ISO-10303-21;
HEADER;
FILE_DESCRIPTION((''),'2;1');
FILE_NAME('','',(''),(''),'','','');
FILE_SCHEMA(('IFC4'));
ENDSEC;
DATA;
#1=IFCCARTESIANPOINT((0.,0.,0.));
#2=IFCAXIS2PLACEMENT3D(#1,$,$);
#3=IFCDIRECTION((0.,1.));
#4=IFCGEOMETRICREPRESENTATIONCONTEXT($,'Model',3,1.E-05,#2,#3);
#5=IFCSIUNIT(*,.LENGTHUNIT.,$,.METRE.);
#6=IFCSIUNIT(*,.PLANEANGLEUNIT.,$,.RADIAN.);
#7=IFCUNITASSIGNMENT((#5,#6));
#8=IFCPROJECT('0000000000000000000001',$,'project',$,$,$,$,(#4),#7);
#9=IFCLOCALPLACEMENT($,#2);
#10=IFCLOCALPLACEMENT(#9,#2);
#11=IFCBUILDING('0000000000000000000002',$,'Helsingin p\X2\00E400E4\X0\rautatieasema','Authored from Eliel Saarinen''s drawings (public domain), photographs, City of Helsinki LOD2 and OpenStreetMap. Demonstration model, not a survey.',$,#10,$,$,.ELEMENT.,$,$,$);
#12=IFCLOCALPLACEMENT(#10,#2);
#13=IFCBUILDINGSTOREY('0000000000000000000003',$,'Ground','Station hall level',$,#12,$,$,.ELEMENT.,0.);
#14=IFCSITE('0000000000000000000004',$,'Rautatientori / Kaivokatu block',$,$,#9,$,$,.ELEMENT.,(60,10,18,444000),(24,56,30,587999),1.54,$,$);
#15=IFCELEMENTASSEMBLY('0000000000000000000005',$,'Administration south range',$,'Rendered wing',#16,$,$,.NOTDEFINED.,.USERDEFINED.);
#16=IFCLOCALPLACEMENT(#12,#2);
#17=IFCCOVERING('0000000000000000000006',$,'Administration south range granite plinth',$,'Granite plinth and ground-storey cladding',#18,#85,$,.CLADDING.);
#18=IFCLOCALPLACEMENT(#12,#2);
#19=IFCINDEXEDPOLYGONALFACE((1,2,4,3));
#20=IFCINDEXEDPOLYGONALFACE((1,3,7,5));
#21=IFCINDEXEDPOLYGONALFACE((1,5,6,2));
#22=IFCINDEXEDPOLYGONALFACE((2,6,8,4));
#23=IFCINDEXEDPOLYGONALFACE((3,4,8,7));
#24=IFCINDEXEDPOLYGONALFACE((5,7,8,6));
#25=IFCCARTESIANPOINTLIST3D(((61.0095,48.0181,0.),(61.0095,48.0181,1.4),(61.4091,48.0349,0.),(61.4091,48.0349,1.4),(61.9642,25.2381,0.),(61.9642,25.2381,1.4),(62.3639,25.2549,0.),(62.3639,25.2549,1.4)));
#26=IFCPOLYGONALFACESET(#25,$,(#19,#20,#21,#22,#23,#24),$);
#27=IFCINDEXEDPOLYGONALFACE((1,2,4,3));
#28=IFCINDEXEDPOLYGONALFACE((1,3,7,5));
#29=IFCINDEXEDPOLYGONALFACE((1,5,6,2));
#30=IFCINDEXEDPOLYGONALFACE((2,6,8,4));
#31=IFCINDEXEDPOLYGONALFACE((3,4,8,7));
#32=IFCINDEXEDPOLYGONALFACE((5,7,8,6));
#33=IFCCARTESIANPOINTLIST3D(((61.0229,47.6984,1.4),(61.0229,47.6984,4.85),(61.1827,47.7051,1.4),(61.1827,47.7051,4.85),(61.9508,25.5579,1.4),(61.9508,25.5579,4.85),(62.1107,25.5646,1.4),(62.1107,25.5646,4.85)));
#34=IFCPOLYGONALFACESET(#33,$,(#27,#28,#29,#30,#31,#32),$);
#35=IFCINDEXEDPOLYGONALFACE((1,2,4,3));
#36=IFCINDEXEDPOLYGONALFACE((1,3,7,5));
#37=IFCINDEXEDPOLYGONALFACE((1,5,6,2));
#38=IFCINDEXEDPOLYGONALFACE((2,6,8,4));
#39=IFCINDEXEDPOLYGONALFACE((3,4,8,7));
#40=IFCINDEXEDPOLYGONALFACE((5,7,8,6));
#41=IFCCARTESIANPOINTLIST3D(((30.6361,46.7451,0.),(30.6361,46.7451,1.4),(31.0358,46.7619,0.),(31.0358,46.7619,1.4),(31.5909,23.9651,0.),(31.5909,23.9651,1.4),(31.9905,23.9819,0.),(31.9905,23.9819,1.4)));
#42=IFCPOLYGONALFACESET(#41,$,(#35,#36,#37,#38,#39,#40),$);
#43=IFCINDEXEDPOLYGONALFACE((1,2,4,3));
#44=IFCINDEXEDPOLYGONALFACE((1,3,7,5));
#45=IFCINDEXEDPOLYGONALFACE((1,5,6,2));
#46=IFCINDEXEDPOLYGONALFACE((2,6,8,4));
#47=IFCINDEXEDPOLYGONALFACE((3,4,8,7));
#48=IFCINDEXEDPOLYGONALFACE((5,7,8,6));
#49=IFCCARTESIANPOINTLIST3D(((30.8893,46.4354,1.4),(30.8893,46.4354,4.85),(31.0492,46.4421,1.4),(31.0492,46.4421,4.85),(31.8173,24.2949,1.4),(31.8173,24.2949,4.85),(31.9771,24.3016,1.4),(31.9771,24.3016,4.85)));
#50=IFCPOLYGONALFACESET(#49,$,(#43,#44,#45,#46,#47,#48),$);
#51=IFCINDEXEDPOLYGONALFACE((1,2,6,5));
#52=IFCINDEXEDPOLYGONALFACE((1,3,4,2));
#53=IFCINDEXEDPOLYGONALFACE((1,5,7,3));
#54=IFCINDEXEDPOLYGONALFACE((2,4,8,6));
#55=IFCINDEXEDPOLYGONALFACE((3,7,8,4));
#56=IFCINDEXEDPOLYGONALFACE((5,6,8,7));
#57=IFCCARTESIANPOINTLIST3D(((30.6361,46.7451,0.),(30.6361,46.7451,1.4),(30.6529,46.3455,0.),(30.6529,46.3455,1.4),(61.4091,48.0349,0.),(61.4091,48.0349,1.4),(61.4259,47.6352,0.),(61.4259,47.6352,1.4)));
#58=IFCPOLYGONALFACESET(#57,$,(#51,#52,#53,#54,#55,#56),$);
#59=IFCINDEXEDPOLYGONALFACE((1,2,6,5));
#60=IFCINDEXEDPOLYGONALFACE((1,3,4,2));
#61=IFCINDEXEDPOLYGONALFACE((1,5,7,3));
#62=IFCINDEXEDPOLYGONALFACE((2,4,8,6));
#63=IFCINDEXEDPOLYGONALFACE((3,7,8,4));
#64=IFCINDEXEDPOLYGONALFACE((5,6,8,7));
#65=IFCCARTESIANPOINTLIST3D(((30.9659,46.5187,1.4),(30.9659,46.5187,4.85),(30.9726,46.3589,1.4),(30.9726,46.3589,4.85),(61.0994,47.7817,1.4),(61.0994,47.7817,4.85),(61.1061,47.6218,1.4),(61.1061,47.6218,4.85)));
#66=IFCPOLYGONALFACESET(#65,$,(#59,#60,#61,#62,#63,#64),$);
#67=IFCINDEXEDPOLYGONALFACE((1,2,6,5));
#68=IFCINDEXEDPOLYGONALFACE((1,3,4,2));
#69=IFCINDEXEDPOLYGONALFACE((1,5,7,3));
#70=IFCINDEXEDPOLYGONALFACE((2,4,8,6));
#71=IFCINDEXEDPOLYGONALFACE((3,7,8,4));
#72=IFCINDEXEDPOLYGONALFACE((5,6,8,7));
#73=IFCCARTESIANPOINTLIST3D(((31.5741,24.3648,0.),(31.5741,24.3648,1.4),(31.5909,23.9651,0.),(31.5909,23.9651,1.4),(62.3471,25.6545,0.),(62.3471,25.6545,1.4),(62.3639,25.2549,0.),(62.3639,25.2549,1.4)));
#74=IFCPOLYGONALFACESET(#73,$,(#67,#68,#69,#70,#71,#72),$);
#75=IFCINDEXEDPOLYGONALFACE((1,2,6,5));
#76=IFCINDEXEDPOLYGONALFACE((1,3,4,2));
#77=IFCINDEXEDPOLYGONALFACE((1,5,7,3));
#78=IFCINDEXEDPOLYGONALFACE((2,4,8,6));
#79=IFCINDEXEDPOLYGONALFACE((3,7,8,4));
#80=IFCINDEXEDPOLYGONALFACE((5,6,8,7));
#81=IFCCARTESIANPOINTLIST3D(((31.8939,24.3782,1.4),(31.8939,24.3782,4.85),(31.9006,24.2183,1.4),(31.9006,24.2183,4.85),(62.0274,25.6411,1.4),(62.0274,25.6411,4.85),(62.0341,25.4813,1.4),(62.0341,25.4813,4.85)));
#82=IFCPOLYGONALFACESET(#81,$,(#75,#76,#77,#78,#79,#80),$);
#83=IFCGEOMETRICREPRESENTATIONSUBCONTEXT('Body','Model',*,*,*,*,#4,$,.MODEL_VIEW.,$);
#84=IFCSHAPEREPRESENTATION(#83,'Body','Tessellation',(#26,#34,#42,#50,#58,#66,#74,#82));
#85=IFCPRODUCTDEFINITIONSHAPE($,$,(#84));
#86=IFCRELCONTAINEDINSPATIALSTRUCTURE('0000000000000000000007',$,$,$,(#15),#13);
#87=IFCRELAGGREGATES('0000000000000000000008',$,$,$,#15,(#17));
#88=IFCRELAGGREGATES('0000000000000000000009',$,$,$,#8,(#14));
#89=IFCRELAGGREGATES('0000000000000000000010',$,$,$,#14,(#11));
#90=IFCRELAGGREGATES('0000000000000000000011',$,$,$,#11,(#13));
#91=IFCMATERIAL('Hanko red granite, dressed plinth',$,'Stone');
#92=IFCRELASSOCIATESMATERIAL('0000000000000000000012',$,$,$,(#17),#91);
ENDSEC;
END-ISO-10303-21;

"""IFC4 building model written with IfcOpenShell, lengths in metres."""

from ifc_helpers import new_model, si_unit, direction, frame, frame_2d, origin, place, context, subcontext, project, spatial, rectangle, extrude, material, element, aggregate, save


model = new_model("IFC4")

# Units and contexts
model_context = context("Model", 3, precision=1e-05, world=origin(), true_north=direction((0.0, 1.0)))
body_context = subcontext(model_context, "Body", "Model", "MODEL_VIEW")
ifc_project = project(units=[si_unit("LENGTHUNIT", "METRE"), si_unit("PLANEANGLEUNIT", "RADIAN")], contexts=[model_context])

# Site, building, storey
site_placement = place(None, origin())
site = spatial("IfcSite", under=ifc_project, at=site_placement, Name="Rautatientori / Kaivokatu block", CompositionType="ELEMENT", RefLatitude=(60, 10, 18, 444000), RefLongitude=(24, 56, 30, 587999), RefElevation=1.54)
building_placement = place(site_placement, origin())
building = spatial("IfcBuilding", under=site, at=building_placement, Name="Helsingin päärautatieasema", Description="Authored from Eliel Saarinen's drawings (public domain), photographs, City of Helsinki LOD2 and OpenStreetMap. Demonstration model, not a survey.", CompositionType="ELEMENT")
storey_placement = place(building_placement, origin())
storey = spatial("IfcBuildingStorey", under=building, at=storey_placement, Name="Ground", Description="Station hall level", CompositionType="ELEMENT", Elevation=0.0)

# Element assembly
assembly_1_placement = place(building_placement, origin())
assembly_1 = element("IfcElementAssembly", 1, at=assembly_1_placement, inside=storey, Name="Administration south range", ObjectType="Rendered wing", AssemblyPlace="NOTDEFINED", PredefinedType="USERDEFINED")
ifc_material_1 = material(Name="Hanko red granite, dressed plinth", Category="Stone")

# Covering
covering_placement = place(building_placement, origin())
covering = element("IfcCovering", 2, at=covering_placement, material=ifc_material_1, Name="Administration south range granite plinth", ObjectType="Granite plinth and ground-storey cladding", PredefinedType="CLADDING", context=body_context, shape_type="SweptSolid", body=[
    extrude(rectangle(XDim=22.8, YDim=0.4, at=frame_2d((0.0, 0.0), x_axis=(-0.041876, 0.999123))), frame((61.6867, 36.6365, 0.0)), (0.0, 0.0, 1.0), 1.4),
    extrude(rectangle(XDim=22.16, YDim=0.16, at=frame_2d((0.0, 0.0), x_axis=(-0.041876, 0.999123))), frame((61.5668, 36.6315, 1.4)), (0.0, 0.0, 1.0), 3.45),
    extrude(rectangle(XDim=22.8, YDim=0.4, at=frame_2d((0.0, 0.0), x_axis=(0.041876, -0.999123))), frame((31.3133, 35.3635, 0.0)), (0.0, 0.0, 1.0), 1.4),
    extrude(rectangle(XDim=22.16, YDim=0.16, at=frame_2d((0.0, 0.0), x_axis=(0.041876, -0.999123))), frame((31.4332, 35.3685, 1.4)), (0.0, 0.0, 1.0), 3.45),
    extrude(rectangle(XDim=30.8, YDim=0.4, at=frame_2d((0.0, 0.0), x_axis=(-0.999123, -0.041876))), frame((46.031, 47.1902, 0.0)), (0.0, 0.0, 1.0), 1.4),
    extrude(rectangle(XDim=30.16, YDim=0.16, at=frame_2d((0.0, 0.0), x_axis=(-0.999123, -0.041876))), frame((46.036, 47.0703, 1.4)), (0.0, 0.0, 1.0), 3.45),
    extrude(rectangle(XDim=30.8, YDim=0.4, at=frame_2d((0.0, 0.0), x_axis=(0.999123, 0.041876))), frame((46.969, 24.8098, 0.0)), (0.0, 0.0, 1.0), 1.4),
    extrude(rectangle(XDim=30.16, YDim=0.16, at=frame_2d((0.0, 0.0), x_axis=(0.999123, 0.041876))), frame((46.964, 24.9297, 1.4)), (0.0, 0.0, 1.0), 3.45),
])

aggregate(assembly_1, [covering])

save(model, "model.ifc")
